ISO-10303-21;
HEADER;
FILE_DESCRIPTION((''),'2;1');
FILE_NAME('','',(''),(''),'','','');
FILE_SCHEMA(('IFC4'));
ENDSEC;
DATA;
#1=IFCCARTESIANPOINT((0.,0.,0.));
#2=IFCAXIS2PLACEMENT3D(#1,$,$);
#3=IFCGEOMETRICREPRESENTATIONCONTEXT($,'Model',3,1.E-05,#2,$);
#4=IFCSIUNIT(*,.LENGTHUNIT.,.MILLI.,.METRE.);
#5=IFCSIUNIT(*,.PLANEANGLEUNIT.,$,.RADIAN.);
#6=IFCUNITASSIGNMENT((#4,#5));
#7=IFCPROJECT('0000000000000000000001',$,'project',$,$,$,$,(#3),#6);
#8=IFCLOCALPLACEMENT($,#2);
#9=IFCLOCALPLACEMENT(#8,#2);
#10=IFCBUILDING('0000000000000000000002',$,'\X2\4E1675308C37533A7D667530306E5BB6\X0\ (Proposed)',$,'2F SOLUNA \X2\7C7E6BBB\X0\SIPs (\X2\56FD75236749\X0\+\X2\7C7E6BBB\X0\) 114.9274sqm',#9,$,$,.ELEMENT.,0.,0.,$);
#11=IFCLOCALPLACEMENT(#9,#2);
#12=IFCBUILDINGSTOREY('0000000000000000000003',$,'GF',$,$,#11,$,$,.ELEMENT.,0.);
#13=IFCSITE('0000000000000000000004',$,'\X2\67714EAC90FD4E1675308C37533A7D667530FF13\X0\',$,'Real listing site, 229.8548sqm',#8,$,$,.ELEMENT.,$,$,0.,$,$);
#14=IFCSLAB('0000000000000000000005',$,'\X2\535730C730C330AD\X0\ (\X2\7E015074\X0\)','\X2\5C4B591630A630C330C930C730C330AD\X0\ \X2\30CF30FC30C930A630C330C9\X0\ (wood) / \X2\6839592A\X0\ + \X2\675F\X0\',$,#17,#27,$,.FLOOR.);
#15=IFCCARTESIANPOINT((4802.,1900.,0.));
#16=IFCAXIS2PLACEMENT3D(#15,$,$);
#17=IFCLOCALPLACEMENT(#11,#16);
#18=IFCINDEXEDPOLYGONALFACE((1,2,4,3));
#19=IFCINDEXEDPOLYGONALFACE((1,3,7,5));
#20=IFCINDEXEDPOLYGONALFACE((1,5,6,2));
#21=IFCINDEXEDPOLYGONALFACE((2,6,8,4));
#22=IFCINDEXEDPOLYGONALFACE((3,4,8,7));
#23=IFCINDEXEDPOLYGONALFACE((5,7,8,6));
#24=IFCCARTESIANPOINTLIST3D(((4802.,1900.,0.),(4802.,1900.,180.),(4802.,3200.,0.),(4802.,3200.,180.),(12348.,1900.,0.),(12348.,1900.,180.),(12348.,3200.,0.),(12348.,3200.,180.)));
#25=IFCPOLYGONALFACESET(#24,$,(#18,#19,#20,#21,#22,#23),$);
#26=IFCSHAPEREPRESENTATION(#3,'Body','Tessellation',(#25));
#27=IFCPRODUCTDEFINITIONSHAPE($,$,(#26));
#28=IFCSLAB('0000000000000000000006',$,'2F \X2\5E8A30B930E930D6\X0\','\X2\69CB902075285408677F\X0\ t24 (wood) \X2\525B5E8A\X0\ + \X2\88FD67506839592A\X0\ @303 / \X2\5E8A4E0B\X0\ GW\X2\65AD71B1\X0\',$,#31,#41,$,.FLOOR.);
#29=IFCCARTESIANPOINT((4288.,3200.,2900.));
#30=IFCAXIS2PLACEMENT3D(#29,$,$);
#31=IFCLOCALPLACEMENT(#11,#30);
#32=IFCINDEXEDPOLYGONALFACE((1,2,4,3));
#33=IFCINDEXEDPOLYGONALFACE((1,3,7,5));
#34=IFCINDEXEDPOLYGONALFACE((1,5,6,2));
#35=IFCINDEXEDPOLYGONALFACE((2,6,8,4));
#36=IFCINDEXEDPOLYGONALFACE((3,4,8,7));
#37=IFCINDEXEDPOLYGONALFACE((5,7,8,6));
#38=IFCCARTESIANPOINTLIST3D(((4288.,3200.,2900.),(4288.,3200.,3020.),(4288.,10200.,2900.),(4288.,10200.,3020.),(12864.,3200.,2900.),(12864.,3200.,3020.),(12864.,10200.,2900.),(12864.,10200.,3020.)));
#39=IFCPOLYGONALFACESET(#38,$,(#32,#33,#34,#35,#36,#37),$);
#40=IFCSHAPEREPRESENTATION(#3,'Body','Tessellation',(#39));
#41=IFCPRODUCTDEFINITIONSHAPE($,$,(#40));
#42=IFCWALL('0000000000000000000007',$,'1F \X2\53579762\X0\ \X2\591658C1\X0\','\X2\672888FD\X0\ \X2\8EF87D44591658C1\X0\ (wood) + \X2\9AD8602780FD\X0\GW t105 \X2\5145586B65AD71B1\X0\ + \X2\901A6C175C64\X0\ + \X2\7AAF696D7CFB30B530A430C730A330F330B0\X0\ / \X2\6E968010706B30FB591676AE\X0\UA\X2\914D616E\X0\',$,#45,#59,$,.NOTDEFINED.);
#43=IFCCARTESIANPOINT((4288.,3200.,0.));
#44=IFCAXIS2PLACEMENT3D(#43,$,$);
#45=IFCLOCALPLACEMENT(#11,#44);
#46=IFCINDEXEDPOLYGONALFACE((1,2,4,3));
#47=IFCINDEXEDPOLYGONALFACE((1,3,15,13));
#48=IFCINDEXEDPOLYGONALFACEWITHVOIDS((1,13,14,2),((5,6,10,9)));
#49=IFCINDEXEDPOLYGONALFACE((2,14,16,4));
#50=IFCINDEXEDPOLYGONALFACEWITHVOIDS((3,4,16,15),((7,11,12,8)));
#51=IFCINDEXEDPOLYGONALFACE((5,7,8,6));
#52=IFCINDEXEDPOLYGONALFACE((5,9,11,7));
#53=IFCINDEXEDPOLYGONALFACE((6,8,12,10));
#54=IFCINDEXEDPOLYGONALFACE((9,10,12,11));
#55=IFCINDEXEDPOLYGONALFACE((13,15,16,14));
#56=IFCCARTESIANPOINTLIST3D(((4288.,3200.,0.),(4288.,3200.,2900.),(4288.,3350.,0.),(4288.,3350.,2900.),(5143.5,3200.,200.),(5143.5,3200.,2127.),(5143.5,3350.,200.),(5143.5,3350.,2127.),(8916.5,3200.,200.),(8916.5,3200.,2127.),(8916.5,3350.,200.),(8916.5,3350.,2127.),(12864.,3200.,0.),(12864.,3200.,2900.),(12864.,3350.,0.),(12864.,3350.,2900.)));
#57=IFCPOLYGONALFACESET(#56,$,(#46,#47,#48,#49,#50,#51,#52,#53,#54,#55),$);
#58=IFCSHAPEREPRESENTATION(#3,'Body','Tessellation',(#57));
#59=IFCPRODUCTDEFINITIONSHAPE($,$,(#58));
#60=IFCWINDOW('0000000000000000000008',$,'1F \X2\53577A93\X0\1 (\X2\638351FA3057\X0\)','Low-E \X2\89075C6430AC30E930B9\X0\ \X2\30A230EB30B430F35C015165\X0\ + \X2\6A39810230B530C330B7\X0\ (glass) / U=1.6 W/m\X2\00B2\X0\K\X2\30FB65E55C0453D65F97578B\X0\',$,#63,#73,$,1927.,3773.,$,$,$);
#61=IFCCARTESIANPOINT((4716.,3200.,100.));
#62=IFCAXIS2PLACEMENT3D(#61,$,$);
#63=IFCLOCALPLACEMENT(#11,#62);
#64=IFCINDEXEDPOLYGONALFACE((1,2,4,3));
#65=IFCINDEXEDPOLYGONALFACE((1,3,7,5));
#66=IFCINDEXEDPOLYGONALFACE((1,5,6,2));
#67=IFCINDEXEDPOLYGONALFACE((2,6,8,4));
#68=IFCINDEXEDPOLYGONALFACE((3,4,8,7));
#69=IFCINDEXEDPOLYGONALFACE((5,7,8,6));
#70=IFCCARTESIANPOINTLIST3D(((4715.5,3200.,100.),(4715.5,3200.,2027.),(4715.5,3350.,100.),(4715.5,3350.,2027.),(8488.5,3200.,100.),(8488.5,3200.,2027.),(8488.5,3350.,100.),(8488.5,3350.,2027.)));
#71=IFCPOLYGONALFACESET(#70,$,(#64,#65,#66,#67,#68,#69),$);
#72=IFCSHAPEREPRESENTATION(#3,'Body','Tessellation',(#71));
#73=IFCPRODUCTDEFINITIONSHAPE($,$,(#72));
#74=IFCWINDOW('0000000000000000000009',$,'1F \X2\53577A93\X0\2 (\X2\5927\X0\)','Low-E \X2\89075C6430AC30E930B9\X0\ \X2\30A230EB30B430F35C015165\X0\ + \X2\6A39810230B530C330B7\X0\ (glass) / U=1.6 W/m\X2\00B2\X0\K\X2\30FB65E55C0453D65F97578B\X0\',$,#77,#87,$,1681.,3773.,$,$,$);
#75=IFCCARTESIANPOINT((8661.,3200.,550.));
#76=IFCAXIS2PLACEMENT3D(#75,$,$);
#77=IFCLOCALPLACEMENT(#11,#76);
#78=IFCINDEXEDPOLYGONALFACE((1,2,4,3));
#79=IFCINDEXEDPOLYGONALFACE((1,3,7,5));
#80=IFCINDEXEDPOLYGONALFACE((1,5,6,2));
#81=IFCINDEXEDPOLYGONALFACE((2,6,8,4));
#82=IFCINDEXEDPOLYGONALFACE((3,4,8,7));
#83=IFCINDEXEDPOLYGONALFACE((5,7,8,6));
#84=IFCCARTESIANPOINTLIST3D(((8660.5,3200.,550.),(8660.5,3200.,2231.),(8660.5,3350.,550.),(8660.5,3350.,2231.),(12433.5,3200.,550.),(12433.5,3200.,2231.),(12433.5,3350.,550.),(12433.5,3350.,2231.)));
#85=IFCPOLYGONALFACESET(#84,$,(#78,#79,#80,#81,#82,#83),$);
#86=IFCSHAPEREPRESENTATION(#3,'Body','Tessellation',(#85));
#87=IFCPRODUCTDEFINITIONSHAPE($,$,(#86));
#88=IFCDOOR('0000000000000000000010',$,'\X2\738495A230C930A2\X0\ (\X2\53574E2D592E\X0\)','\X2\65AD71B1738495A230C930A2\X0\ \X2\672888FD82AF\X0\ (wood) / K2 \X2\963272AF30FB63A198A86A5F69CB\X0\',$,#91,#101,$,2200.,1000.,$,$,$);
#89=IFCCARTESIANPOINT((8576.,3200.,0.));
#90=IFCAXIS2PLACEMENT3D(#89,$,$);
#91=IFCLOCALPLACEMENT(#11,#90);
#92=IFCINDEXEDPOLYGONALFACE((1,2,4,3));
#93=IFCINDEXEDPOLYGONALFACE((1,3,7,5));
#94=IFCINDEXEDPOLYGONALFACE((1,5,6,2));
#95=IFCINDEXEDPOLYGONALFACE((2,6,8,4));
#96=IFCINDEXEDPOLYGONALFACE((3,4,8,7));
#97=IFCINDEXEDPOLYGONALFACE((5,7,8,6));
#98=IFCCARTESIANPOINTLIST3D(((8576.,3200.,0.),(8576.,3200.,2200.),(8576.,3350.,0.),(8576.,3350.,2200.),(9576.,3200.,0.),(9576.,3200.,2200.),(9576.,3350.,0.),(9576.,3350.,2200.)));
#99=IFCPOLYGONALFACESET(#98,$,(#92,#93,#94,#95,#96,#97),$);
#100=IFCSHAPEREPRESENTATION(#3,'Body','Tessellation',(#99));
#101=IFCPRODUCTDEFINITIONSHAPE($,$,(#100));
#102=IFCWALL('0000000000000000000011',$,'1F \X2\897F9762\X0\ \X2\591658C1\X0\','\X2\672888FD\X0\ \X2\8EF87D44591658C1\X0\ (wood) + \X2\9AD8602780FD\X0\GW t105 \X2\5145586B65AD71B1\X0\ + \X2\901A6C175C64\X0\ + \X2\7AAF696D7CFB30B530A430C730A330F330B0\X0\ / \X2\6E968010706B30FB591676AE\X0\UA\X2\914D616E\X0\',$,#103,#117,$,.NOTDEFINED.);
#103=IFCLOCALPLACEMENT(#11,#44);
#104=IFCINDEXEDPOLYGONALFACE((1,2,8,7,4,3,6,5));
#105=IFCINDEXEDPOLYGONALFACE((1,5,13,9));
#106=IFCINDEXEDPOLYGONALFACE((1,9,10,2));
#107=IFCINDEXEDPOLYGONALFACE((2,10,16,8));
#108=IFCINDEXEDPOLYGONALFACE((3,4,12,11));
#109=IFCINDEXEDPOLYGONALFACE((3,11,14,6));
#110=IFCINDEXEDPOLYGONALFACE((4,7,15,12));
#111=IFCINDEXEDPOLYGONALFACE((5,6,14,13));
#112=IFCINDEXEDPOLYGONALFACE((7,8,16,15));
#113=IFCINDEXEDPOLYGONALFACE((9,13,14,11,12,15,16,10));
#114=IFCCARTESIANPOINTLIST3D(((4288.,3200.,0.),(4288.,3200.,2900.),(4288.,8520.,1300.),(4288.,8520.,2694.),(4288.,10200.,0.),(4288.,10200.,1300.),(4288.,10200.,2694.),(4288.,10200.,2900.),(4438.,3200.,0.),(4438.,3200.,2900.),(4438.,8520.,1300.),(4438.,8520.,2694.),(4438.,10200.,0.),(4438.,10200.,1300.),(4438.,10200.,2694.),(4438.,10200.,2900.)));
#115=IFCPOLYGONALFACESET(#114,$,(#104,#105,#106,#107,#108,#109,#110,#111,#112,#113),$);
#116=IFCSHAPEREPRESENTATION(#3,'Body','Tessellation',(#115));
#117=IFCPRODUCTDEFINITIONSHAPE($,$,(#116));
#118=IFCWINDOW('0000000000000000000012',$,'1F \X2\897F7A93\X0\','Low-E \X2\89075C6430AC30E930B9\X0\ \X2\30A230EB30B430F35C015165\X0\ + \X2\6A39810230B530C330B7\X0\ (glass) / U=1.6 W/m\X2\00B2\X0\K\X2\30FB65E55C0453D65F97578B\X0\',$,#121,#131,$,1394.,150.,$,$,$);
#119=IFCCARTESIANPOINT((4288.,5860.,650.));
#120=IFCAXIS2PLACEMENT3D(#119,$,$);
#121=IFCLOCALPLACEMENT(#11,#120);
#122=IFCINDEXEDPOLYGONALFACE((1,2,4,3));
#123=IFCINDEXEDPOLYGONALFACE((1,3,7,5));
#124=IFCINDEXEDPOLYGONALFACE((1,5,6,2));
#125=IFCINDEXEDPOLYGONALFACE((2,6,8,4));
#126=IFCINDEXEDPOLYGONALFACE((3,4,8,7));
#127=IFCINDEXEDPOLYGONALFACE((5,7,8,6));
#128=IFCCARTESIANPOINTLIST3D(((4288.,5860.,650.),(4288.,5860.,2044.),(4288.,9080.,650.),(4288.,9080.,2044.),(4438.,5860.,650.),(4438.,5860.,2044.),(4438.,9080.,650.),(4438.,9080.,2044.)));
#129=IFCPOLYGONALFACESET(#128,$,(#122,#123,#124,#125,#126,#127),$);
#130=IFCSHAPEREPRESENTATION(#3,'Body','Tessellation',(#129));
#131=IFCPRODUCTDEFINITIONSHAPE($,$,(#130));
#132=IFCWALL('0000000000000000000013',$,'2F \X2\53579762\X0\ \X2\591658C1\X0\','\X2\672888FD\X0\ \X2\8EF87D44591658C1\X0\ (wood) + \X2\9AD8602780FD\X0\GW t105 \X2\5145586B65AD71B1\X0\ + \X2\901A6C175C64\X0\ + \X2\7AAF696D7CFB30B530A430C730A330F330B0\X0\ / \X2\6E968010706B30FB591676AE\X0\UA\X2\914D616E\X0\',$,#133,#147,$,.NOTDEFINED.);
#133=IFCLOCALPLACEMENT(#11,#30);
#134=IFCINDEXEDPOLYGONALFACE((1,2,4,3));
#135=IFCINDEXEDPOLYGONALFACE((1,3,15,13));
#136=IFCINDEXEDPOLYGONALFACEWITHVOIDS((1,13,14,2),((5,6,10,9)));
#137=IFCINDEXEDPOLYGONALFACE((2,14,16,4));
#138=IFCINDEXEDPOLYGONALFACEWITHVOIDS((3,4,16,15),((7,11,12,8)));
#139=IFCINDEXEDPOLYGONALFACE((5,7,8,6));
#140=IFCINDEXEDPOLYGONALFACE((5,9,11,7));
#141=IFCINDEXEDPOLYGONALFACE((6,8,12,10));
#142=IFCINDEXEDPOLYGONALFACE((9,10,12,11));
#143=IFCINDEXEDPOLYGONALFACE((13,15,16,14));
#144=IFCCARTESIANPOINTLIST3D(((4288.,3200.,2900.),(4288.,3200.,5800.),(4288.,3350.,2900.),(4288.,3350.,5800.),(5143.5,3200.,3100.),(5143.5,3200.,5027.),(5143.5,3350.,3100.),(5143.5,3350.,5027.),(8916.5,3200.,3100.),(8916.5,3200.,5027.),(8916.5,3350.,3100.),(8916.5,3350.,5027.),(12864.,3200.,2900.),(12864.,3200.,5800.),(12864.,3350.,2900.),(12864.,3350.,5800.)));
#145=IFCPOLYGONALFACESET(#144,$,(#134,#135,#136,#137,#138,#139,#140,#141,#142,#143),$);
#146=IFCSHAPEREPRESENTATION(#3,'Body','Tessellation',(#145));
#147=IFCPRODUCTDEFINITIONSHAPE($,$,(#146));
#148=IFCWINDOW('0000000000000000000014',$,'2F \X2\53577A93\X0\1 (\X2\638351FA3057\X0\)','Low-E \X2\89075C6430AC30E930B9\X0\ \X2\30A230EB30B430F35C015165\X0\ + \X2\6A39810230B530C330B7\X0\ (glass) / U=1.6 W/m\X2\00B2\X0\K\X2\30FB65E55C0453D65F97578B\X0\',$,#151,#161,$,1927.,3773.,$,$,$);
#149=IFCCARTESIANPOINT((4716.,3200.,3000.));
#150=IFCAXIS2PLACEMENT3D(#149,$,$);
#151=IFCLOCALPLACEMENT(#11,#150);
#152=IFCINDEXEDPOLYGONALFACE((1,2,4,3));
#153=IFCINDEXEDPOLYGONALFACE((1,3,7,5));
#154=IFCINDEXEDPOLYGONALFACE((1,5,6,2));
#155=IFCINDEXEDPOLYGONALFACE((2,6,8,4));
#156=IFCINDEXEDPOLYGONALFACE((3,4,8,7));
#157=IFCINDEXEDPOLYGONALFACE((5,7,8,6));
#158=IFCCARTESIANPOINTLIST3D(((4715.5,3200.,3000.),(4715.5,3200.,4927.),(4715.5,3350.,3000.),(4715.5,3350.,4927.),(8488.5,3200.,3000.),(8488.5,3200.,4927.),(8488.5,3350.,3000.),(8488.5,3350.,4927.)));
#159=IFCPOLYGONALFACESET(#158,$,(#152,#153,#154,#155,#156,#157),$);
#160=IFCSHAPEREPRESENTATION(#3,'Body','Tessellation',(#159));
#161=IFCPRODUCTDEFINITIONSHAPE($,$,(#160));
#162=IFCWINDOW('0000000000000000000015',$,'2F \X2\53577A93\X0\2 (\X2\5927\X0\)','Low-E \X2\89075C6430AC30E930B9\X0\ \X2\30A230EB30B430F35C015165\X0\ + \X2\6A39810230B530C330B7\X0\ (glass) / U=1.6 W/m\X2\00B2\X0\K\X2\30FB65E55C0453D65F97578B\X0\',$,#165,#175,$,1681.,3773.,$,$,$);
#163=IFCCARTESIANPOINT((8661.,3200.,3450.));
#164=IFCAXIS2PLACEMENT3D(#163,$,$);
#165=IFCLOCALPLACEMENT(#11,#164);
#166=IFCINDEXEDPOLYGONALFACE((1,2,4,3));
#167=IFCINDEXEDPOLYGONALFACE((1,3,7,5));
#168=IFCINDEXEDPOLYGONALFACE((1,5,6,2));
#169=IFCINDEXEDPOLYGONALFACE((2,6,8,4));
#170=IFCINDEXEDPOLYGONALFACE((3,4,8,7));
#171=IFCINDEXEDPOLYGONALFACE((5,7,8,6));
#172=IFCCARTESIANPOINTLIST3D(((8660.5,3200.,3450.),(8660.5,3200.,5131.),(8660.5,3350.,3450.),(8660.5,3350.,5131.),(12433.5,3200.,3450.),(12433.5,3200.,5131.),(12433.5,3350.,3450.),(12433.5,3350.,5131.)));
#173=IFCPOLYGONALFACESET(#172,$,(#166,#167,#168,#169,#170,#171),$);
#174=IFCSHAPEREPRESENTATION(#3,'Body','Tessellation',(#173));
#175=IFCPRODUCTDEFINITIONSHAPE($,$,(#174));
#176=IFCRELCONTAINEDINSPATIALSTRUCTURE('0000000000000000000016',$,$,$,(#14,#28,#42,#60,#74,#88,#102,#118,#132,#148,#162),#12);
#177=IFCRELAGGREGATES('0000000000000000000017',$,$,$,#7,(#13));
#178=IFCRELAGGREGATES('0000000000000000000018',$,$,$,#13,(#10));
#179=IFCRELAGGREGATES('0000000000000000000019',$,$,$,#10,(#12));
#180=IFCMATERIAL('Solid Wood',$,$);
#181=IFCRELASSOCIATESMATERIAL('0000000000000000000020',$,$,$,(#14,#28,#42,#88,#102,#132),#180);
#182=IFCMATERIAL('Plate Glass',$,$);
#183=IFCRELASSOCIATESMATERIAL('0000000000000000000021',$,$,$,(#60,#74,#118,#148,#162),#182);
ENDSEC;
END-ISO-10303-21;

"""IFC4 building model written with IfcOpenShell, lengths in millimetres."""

from ifc_helpers import new_model, si_unit, frame, frame_2d, origin, place, context, project, spatial, rectangle, extrude, material, element, fill, save


model = new_model("IFC4")

# Units and contexts
model_context = context("Model", 3, precision=1e-05, world=origin())
ifc_project = project(units=[si_unit("LENGTHUNIT", "METRE", prefix="MILLI"), si_unit("PLANEANGLEUNIT", "RADIAN")], contexts=[model_context])

# Site, building, storey
site_placement = place(None, origin())
site = spatial("IfcSite", under=ifc_project, at=site_placement, Name="東京都世田谷区給田３", ObjectType="Real listing site, 229.8548sqm", CompositionType="ELEMENT", RefElevation=0.0)
building_placement = place(site_placement, origin())
building = spatial("IfcBuilding", under=site, at=building_placement, Name="世田谷区給田の家 (Proposed)", ObjectType="2F SOLUNA 籾殻SIPs (国産杉+籾殻) 114.9274sqm", CompositionType="ELEMENT", ElevationOfRefHeight=0.0, ElevationOfTerrain=0.0)
storey_placement = place(building_placement, origin())
storey = spatial("IfcBuildingStorey", under=building, at=storey_placement, Name="GF", CompositionType="ELEMENT", Elevation=0.0)

# Slabs
ifc_material_1 = material(Name="Solid Wood")
slab_1_placement = place(storey_placement, frame((4802.0, 1900.0, 0.0)))
element("IfcSlab", 1, at=slab_1_placement, inside=storey, material=ifc_material_1, Name="南デッキ (縁側)", Description="屋外ウッドデッキ ハードウッド (wood) / 根太 + 束", PredefinedType="FLOOR", context=model_context, shape_type="SweptSolid", body=[
    extrude(rectangle(XDim=7546.0, YDim=1300.0, at=frame_2d((3773.0, 650.0))), frame((4802.0, 1900.0, 0.0)), (0.0, 0.0, 1.0), 180.0),
])
slab_2_placement = place(storey_placement, frame((4288.0, 3200.0, 2900.0)))
element("IfcSlab", 2, at=slab_2_placement, inside=storey, material=ifc_material_1, Name="2F 床スラブ", Description="構造用合板 t24 (wood) 剛床 + 製材根太 @303 / 床下 GW断熱", PredefinedType="FLOOR", context=model_context, shape_type="SweptSolid", body=[
    extrude(rectangle(XDim=8576.0, YDim=7000.0, at=frame_2d((4288.0, 3500.0))), frame((4288.0, 3200.0, 2900.0)), (0.0, 0.0, 1.0), 120.0),
])

# Wall, openings, windows, door
wall_1_placement = place(storey_placement, frame((4288.0, 3200.0, 0.0)))
wall_1 = element("IfcWall", 3, at=wall_1_placement, inside=storey, material=ifc_material_1, Name="1F 南面 外壁", Description="木製 軸組外壁 (wood) + 高性能GW t105 充填断熱 + 通気層 + 窯業系サイディング / 準耐火・外皮UA配慮", PredefinedType="NOTDEFINED", context=model_context, shape_type="SweptSolid", body=[
    extrude(rectangle(XDim=8576.0, YDim=150.0, at=frame_2d((4288.0, 75.0))), frame((4288.0, 3200.0, 0.0)), (0.0, 0.0, 1.0), 2900.0),
])
opening_1_placement = place(storey_placement, frame((4716.0, 3200.0, 100.0)))
opening_1 = element("IfcOpeningElement", 4, at=opening_1_placement, cuts=wall_1, PredefinedType="NOTDEFINED", context=model_context, shape_type="SweptSolid", body=[
    extrude(rectangle(XDim=3773.0, YDim=150.0, at=frame_2d((1886.0, 75.0))), frame((4716.0, 3200.0, 100.0)), (0.0, 0.0, 1.0), 1927.0),
])
opening_2_placement = place(storey_placement, frame((8661.0, 3200.0, 550.0)))
opening_2 = element("IfcOpeningElement", 5, at=opening_2_placement, cuts=wall_1, PredefinedType="NOTDEFINED", context=model_context, shape_type="SweptSolid", body=[
    extrude(rectangle(XDim=3773.0, YDim=150.0, at=frame_2d((1886.0, 75.0))), frame((8661.0, 3200.0, 550.0)), (0.0, 0.0, 1.0), 1681.0),
])
opening_3_placement = place(storey_placement, frame((8576.0, 3200.0, 0.0)))
opening_3 = element("IfcOpeningElement", 6, at=opening_3_placement, cuts=wall_1, PredefinedType="NOTDEFINED", context=model_context, shape_type="SweptSolid", body=[
    extrude(rectangle(XDim=1000.0, YDim=150.0, at=frame_2d((500.0, 75.0))), frame((8576.0, 3200.0, 0.0)), (0.0, 0.0, 1.0), 2200.0),
])
ifc_material_2 = material(Name="Plate Glass")
window_1_placement = place(storey_placement, frame((4716.0, 3200.0, 100.0)))
window_1 = element("IfcWindow", 7, at=window_1_placement, inside=storey, material=ifc_material_2, Name="1F 南窓1 (掃出し)", Description="Low-E 複層ガラス アルゴン封入 + 樹脂サッシ (glass) / U=1.6 W/m²K・日射取得型", OverallHeight=1927.0, OverallWidth=3773.0, context=model_context, shape_type="SweptSolid", body=[
    extrude(rectangle(XDim=3773.0, YDim=150.0, at=frame_2d((1886.0, 75.0))), frame((4716.0, 3200.0, 100.0)), (0.0, 0.0, 1.0), 1927.0),
])
fill(opening_1, window_1)
window_2_placement = place(storey_placement, frame((8661.0, 3200.0, 550.0)))
window_2 = element("IfcWindow", 8, at=window_2_placement, inside=storey, material=ifc_material_2, Name="1F 南窓2 (大)", Description="Low-E 複層ガラス アルゴン封入 + 樹脂サッシ (glass) / U=1.6 W/m²K・日射取得型", OverallHeight=1681.0, OverallWidth=3773.0, context=model_context, shape_type="SweptSolid", body=[
    extrude(rectangle(XDim=3773.0, YDim=150.0, at=frame_2d((1886.0, 75.0))), frame((8661.0, 3200.0, 550.0)), (0.0, 0.0, 1.0), 1681.0),
])
fill(opening_2, window_2)
door_placement = place(storey_placement, frame((8576.0, 3200.0, 0.0)))
door = element("IfcDoor", 9, at=door_placement, inside=storey, material=ifc_material_1, Name="玄関ドア (南中央)", Description="断熱玄関ドア 木製芯 (wood) / K2 防犯・採風機構", OverallHeight=2200.0, OverallWidth=1000.0, context=model_context, shape_type="SweptSolid", body=[
    extrude(rectangle(XDim=1000.0, YDim=150.0, at=frame_2d((500.0, 75.0))), frame((8576.0, 3200.0, 0.0)), (0.0, 0.0, 1.0), 2200.0),
])
fill(opening_3, door)

# Wall, opening, window
wall_2_placement = place(storey_placement, frame((4288.0, 3200.0, 0.0)))
wall_2 = element("IfcWall", 10, at=wall_2_placement, inside=storey, material=ifc_material_1, Name="1F 西面 外壁", Description="木製 軸組外壁 (wood) + 高性能GW t105 充填断熱 + 通気層 + 窯業系サイディング / 準耐火・外皮UA配慮", PredefinedType="NOTDEFINED", context=model_context, shape_type="SweptSolid", body=[
    extrude(rectangle(XDim=150.0, YDim=7000.0, at=frame_2d((75.0, 3500.0))), frame((4288.0, 3200.0, 0.0)), (0.0, 0.0, 1.0), 2900.0),
])
opening_4_placement = place(storey_placement, frame((4288.0, 5860.0, 650.0)))
opening_4 = element("IfcOpeningElement", 11, at=opening_4_placement, cuts=wall_2, PredefinedType="NOTDEFINED", context=model_context, shape_type="SweptSolid", body=[
    extrude(rectangle(XDim=150.0, YDim=3220.0, at=frame_2d((75.0, 1610.0))), frame((4288.0, 5860.0, 650.0)), (0.0, 0.0, 1.0), 1394.0),
])
window_3_placement = place(storey_placement, frame((4288.0, 5860.0, 650.0)))
window_3 = element("IfcWindow", 12, at=window_3_placement, inside=storey, material=ifc_material_2, Name="1F 西窓", Description="Low-E 複層ガラス アルゴン封入 + 樹脂サッシ (glass) / U=1.6 W/m²K・日射取得型", OverallHeight=1394.0, OverallWidth=150.0, context=model_context, shape_type="SweptSolid", body=[
    extrude(rectangle(XDim=150.0, YDim=3220.0, at=frame_2d((75.0, 1610.0))), frame((4288.0, 5860.0, 650.0)), (0.0, 0.0, 1.0), 1394.0),
])
fill(opening_4, window_3)

# Wall, openings, windows
wall_3_placement = place(storey_placement, frame((4288.0, 3200.0, 2900.0)))
wall_3 = element("IfcWall", 13, at=wall_3_placement, inside=storey, material=ifc_material_1, Name="2F 南面 外壁", Description="木製 軸組外壁 (wood) + 高性能GW t105 充填断熱 + 通気層 + 窯業系サイディング / 準耐火・外皮UA配慮", PredefinedType="NOTDEFINED", context=model_context, shape_type="SweptSolid", body=[
    extrude(rectangle(XDim=8576.0, YDim=150.0, at=frame_2d((4288.0, 75.0))), frame((4288.0, 3200.0, 2900.0)), (0.0, 0.0, 1.0), 2900.0),
])
opening_5_placement = place(storey_placement, frame((4716.0, 3200.0, 3000.0)))
opening_5 = element("IfcOpeningElement", 14, at=opening_5_placement, cuts=wall_3, PredefinedType="NOTDEFINED", context=model_context, shape_type="SweptSolid", body=[
    extrude(rectangle(XDim=3773.0, YDim=150.0, at=frame_2d((1886.0, 75.0))), frame((4716.0, 3200.0, 3000.0)), (0.0, 0.0, 1.0), 1927.0),
])
opening_6_placement = place(storey_placement, frame((8661.0, 3200.0, 3450.0)))
opening_6 = element("IfcOpeningElement", 15, at=opening_6_placement, cuts=wall_3, PredefinedType="NOTDEFINED", context=model_context, shape_type="SweptSolid", body=[
    extrude(rectangle(XDim=3773.0, YDim=150.0, at=frame_2d((1886.0, 75.0))), frame((8661.0, 3200.0, 3450.0)), (0.0, 0.0, 1.0), 1681.0),
])
window_4_placement = place(storey_placement, frame((4716.0, 3200.0, 3000.0)))
window_4 = element("IfcWindow", 16, at=window_4_placement, inside=storey, material=ifc_material_2, Name="2F 南窓1 (掃出し)", Description="Low-E 複層ガラス アルゴン封入 + 樹脂サッシ (glass) / U=1.6 W/m²K・日射取得型", OverallHeight=1927.0, OverallWidth=3773.0, context=model_context, shape_type="SweptSolid", body=[
    extrude(rectangle(XDim=3773.0, YDim=150.0, at=frame_2d((1886.0, 75.0))), frame((4716.0, 3200.0, 3000.0)), (0.0, 0.0, 1.0), 1927.0),
])
fill(opening_5, window_4)
window_5_placement = place(storey_placement, frame((8661.0, 3200.0, 3450.0)))
window_5 = element("IfcWindow", 17, at=window_5_placement, inside=storey, material=ifc_material_2, Name="2F 南窓2 (大)", Description="Low-E 複層ガラス アルゴン封入 + 樹脂サッシ (glass) / U=1.6 W/m²K・日射取得型", OverallHeight=1681.0, OverallWidth=3773.0, context=model_context, shape_type="SweptSolid", body=[
    extrude(rectangle(XDim=3773.0, YDim=150.0, at=frame_2d((1886.0, 75.0))), frame((8661.0, 3200.0, 3450.0)), (0.0, 0.0, 1.0), 1681.0),
])
fill(opening_6, window_5)

save(model, "model.ifc")
